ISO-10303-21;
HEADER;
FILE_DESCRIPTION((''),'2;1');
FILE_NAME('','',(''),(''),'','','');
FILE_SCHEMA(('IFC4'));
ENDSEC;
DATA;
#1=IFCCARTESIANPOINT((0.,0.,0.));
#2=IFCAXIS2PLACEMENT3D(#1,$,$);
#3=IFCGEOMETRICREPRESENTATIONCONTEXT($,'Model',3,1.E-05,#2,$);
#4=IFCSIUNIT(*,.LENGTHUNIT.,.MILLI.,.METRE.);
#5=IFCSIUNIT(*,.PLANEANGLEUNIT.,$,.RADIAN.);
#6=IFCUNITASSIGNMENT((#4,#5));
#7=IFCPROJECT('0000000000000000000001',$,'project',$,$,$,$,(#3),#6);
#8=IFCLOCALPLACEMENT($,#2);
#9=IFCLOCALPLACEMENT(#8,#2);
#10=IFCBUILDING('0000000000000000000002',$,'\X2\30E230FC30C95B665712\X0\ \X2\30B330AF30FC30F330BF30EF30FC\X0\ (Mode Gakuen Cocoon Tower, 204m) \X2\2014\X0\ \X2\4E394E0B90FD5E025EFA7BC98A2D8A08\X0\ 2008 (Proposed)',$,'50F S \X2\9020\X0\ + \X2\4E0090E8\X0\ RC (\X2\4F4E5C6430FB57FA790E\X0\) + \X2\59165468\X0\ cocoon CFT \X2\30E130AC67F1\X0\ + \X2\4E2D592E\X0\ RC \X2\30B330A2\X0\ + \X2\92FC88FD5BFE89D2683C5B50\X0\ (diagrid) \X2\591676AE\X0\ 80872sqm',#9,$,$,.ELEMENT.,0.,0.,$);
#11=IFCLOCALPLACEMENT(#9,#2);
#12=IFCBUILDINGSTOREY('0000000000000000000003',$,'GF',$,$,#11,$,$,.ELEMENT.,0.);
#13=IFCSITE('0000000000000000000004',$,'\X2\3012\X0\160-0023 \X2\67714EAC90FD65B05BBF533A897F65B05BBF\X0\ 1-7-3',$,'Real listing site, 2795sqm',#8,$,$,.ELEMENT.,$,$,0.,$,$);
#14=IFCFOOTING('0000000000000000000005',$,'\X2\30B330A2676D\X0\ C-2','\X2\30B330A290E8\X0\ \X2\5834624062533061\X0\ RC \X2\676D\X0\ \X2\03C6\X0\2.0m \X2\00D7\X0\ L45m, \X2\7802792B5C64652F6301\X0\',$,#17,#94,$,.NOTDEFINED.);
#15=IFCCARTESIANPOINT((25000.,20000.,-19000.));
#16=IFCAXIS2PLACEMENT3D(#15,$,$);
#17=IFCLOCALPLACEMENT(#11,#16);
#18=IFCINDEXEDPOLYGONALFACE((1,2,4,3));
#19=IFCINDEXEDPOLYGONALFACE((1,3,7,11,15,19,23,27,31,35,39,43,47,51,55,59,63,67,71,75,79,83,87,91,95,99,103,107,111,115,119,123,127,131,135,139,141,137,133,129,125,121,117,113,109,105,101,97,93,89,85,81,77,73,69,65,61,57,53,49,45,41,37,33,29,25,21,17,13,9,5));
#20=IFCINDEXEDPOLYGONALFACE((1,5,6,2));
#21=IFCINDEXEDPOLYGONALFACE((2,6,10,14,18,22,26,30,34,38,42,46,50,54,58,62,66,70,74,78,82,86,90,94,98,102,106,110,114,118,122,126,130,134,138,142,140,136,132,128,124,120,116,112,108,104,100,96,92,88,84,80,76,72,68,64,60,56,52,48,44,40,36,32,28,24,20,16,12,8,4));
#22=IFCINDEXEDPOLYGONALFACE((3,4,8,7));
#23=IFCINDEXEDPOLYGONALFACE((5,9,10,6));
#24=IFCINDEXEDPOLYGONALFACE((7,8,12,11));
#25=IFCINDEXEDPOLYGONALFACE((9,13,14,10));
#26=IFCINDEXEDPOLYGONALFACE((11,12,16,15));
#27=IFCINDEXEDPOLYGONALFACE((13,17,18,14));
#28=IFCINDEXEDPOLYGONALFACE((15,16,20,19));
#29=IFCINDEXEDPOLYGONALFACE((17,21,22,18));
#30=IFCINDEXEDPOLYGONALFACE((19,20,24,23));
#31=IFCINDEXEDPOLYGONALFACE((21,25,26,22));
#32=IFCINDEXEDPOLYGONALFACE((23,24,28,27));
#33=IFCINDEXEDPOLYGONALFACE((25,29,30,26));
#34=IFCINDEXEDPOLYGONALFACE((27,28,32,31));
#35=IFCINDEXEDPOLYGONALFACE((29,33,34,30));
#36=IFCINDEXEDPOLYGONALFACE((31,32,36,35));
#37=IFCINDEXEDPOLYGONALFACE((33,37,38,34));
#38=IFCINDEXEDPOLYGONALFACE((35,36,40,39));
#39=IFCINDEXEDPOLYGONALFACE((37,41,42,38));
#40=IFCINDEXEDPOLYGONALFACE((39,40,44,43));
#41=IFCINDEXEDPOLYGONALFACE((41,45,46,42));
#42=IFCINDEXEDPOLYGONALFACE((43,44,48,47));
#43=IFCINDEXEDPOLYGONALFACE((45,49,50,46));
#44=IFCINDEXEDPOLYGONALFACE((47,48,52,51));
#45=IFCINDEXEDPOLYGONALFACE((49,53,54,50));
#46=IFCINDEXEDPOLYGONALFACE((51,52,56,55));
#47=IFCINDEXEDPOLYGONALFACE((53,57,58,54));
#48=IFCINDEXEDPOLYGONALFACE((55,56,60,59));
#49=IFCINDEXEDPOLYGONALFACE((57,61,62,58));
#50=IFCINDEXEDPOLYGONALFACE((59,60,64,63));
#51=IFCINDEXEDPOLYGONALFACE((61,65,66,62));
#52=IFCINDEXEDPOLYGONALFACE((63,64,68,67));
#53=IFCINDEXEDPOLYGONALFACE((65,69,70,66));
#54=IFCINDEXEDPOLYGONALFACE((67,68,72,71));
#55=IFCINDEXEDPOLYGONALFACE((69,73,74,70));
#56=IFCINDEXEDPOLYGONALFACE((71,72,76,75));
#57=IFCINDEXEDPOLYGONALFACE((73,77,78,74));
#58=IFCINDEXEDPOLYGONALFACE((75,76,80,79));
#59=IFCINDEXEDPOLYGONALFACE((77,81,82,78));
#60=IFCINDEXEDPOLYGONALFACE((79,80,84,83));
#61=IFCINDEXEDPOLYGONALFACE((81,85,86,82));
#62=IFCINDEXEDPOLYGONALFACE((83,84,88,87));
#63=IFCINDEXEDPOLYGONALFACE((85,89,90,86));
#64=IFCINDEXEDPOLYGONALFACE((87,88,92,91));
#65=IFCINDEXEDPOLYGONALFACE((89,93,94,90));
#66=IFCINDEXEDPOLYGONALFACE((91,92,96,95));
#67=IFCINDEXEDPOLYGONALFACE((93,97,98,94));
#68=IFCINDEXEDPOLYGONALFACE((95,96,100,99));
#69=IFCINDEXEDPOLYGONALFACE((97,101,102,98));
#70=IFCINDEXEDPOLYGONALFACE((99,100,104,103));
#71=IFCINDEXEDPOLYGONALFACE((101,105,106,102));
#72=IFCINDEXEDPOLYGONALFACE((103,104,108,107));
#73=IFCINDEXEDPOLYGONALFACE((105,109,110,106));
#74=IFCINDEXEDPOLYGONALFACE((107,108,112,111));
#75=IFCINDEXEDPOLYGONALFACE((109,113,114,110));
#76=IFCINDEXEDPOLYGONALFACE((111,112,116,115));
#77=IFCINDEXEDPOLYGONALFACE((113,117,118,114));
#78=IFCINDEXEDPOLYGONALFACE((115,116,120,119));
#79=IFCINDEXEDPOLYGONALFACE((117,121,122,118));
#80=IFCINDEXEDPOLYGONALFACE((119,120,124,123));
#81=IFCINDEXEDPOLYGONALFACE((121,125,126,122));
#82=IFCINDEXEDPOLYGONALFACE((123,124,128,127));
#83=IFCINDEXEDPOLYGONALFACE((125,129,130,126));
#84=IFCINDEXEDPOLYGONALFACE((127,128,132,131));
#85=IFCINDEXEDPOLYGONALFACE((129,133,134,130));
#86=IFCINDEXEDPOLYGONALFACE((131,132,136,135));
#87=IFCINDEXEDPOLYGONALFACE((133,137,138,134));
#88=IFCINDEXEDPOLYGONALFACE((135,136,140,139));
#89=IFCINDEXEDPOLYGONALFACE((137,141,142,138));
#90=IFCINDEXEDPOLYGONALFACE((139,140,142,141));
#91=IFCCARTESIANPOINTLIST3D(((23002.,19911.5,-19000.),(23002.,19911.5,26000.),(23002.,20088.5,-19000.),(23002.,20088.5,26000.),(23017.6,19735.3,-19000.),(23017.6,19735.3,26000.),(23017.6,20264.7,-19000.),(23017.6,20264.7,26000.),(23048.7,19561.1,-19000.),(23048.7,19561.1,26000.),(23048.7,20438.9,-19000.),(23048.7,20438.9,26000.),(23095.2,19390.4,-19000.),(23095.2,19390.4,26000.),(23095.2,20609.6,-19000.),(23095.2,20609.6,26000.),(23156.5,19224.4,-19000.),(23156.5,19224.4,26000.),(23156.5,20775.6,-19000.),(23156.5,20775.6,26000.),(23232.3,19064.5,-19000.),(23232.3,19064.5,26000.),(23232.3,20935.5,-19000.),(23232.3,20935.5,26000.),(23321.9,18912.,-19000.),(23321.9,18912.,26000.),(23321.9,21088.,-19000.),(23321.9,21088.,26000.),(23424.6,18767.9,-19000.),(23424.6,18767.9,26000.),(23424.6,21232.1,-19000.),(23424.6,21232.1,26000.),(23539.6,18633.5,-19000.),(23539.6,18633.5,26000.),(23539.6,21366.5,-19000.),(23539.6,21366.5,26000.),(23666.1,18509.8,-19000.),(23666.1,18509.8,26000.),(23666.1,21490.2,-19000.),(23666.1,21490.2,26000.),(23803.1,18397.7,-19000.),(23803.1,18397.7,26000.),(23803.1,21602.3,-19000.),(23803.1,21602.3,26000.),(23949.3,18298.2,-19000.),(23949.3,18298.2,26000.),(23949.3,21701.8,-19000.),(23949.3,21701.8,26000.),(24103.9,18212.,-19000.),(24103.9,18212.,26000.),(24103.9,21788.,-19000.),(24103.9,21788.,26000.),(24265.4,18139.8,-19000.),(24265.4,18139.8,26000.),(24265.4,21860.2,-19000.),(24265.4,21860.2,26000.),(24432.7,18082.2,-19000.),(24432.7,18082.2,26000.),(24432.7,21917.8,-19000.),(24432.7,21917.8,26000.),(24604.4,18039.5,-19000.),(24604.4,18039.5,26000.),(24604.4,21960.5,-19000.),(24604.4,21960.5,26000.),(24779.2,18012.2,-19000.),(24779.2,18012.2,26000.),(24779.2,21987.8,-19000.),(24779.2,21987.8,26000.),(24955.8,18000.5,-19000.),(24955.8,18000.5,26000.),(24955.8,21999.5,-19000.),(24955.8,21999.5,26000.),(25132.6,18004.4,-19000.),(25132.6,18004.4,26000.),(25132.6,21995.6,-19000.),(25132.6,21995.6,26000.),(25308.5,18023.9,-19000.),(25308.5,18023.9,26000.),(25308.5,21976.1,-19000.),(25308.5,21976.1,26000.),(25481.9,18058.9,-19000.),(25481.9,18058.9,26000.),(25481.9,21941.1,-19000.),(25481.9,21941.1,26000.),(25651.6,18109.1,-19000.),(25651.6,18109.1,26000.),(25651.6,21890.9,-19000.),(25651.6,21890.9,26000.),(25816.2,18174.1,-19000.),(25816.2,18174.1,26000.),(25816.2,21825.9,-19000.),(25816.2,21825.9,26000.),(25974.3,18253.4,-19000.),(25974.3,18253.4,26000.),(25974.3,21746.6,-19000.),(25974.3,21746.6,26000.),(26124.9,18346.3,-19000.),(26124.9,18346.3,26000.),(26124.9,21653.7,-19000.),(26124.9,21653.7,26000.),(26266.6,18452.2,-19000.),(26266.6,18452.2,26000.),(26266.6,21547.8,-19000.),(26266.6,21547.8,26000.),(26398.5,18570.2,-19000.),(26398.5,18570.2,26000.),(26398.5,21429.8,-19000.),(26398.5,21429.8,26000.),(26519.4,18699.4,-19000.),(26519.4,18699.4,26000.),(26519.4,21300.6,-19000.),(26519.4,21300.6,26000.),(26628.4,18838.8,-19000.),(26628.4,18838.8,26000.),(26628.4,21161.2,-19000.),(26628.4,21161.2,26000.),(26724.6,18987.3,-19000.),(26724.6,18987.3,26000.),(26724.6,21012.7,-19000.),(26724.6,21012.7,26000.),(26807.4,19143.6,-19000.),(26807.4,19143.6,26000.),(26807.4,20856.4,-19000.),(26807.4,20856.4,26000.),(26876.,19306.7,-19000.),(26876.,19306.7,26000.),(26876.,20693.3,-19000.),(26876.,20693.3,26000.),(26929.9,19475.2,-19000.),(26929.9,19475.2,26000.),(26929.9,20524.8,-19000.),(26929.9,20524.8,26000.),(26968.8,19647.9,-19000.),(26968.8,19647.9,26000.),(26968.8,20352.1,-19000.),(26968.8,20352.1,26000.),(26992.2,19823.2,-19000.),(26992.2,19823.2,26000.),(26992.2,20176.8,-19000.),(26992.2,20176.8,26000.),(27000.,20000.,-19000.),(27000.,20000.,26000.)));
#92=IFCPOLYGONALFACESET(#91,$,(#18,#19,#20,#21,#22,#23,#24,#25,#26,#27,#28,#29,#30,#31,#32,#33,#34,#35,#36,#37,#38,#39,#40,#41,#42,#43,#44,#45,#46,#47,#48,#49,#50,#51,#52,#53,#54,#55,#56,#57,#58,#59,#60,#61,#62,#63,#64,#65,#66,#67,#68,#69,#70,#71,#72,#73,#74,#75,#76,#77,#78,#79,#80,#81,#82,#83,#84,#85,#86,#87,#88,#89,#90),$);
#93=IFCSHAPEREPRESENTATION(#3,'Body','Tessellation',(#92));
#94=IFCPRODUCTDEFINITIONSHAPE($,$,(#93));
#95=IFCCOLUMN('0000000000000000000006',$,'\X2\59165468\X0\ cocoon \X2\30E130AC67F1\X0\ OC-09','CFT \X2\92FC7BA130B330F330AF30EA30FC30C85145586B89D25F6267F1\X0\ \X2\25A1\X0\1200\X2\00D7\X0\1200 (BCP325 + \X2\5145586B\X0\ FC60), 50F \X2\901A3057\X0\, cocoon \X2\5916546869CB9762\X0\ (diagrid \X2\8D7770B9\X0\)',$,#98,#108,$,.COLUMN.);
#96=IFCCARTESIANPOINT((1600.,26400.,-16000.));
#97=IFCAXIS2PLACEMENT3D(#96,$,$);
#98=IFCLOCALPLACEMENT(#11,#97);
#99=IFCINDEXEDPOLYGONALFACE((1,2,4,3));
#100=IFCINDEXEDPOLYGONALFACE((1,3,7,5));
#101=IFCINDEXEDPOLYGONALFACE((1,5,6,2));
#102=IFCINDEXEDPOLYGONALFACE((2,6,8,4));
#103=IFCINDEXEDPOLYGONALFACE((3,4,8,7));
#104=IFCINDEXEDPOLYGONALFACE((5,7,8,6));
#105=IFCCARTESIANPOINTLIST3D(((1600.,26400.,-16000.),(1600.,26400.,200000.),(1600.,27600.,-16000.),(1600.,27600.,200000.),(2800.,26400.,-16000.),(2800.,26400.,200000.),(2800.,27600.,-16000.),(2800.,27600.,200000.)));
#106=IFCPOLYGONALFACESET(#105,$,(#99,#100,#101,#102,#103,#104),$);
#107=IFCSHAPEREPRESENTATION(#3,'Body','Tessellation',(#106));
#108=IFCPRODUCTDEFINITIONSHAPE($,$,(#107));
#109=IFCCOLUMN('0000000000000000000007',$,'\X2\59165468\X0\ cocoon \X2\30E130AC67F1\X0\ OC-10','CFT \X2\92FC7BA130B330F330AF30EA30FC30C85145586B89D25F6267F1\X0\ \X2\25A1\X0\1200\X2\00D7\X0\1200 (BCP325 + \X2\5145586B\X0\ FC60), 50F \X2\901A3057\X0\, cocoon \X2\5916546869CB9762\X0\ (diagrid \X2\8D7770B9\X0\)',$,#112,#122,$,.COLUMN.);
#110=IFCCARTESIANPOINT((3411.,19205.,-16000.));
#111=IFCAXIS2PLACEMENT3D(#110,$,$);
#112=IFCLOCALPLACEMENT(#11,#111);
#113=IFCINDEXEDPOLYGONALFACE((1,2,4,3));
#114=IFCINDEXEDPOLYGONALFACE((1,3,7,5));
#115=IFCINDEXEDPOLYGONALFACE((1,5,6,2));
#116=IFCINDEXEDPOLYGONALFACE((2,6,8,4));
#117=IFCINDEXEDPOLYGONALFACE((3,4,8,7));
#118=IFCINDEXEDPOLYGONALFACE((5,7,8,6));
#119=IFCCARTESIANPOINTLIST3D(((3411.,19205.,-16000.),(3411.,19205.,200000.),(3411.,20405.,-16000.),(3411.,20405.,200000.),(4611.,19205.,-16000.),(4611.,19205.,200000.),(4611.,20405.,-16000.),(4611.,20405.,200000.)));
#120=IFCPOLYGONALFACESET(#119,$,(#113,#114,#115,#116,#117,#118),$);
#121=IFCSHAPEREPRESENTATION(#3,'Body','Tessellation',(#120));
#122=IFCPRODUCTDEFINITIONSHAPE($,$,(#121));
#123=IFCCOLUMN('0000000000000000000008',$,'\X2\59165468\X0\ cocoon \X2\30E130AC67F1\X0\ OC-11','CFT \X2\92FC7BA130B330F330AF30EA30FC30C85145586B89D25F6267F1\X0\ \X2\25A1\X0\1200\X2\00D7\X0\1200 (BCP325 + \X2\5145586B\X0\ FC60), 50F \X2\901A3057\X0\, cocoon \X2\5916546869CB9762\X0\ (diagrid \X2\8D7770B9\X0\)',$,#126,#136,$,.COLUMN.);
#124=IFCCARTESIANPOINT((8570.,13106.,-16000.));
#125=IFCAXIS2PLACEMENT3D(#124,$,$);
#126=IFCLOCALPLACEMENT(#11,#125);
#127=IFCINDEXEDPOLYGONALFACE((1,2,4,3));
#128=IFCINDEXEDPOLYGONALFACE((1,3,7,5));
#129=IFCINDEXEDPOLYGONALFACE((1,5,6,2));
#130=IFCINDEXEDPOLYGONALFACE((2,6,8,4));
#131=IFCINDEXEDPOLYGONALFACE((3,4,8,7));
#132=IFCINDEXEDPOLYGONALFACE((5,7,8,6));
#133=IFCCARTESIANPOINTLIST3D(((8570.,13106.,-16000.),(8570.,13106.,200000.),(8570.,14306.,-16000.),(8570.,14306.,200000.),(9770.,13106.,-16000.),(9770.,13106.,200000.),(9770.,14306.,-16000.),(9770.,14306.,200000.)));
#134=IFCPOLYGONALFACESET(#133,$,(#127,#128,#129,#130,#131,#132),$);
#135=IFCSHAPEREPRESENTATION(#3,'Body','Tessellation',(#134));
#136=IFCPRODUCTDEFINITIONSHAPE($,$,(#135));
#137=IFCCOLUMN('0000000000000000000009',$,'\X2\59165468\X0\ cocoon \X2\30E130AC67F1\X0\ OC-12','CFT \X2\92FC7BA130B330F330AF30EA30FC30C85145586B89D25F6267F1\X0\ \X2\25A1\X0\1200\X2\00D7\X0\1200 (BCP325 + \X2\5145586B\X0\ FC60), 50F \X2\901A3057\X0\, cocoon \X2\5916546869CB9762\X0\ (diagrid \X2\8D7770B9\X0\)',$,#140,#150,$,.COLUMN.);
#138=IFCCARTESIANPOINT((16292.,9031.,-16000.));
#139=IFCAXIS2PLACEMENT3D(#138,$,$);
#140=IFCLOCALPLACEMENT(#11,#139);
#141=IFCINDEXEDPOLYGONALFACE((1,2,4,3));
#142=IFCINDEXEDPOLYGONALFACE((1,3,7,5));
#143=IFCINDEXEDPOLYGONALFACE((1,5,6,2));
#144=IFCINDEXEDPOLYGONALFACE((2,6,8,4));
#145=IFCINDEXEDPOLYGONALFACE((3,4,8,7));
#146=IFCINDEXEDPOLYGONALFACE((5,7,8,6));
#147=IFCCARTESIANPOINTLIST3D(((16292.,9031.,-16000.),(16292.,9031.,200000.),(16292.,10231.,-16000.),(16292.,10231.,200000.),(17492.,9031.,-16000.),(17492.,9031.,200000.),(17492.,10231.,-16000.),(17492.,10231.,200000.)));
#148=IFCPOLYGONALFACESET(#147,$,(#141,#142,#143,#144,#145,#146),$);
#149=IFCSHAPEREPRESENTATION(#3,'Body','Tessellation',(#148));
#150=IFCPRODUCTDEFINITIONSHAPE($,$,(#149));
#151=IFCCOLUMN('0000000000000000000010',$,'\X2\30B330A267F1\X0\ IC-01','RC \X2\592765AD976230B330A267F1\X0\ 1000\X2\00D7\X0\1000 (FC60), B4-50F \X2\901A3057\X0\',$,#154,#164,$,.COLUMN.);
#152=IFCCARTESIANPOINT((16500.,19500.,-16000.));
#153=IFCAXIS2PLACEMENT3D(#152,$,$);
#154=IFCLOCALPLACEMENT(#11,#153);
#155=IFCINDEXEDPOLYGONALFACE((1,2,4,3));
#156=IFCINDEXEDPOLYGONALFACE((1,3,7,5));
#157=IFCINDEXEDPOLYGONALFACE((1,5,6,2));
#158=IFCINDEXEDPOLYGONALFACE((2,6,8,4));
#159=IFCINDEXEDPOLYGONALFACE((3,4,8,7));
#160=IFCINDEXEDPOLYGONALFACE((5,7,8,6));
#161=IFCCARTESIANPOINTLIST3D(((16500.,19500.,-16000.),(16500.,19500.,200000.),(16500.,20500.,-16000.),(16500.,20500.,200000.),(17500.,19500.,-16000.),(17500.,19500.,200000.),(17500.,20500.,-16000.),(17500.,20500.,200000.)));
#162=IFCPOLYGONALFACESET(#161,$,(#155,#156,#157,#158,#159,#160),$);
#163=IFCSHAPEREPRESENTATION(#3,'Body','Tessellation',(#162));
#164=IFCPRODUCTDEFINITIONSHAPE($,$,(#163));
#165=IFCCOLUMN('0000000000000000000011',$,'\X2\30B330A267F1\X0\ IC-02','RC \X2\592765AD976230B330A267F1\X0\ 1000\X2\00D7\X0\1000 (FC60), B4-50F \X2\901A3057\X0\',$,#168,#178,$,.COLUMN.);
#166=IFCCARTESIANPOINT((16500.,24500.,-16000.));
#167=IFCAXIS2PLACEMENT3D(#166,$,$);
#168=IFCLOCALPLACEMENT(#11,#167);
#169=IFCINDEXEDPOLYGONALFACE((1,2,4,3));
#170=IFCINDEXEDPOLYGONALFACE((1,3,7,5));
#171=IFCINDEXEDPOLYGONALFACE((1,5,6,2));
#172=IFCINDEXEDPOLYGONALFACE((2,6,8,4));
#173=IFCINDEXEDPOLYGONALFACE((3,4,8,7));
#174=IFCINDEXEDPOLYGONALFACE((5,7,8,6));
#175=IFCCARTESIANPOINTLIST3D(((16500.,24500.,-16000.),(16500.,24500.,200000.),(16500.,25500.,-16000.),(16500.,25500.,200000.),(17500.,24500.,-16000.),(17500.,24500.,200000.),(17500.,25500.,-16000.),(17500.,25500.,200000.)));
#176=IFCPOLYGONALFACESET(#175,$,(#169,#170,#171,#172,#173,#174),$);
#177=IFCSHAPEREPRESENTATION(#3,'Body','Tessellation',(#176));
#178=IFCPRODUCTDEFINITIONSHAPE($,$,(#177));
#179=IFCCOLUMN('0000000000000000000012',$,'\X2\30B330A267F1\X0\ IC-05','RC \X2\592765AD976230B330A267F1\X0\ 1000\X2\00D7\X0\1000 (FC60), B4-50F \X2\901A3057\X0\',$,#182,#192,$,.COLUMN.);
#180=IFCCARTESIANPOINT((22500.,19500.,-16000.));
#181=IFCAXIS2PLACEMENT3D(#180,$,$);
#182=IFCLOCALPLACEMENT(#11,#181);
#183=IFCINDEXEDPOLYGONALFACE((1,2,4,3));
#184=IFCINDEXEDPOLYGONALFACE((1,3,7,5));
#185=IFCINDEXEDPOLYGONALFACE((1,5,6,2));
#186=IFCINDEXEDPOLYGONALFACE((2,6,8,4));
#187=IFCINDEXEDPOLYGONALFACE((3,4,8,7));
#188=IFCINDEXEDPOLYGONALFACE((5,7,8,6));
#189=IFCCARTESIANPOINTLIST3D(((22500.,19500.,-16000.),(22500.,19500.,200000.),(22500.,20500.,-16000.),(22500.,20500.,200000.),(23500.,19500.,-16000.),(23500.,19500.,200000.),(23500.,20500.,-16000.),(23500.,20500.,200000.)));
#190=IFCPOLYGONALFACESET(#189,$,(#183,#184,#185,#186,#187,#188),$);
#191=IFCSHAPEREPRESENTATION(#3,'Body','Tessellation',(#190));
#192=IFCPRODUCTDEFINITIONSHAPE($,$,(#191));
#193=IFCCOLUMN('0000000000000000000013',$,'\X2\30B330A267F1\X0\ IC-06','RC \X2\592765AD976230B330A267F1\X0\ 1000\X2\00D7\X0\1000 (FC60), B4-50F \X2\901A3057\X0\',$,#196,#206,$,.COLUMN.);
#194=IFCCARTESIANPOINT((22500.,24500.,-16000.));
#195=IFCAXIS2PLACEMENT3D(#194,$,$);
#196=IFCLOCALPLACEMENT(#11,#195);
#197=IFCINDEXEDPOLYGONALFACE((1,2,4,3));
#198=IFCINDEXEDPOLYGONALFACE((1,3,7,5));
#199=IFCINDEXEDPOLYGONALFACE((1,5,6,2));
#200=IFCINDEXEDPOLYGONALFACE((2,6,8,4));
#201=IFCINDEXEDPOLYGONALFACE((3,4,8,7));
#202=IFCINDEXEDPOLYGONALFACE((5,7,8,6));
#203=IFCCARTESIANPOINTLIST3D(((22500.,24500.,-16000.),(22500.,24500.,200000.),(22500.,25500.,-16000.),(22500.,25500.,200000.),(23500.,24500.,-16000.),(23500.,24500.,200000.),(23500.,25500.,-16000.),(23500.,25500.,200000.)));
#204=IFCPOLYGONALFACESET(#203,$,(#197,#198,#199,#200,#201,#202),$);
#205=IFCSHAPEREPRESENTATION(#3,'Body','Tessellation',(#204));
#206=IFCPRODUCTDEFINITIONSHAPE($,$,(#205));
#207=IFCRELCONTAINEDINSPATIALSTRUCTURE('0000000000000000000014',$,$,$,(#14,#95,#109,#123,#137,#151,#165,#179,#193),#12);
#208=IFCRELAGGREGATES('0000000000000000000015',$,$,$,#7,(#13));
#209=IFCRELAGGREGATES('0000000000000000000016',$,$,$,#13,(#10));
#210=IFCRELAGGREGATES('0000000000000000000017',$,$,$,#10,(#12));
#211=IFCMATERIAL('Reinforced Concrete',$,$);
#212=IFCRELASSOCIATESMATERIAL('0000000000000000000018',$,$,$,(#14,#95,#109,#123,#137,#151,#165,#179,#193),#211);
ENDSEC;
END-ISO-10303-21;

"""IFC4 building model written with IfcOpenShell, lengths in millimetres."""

from ifc_helpers import new_model, si_unit, frame, frame_2d, origin, origin_2d, place, context, project, spatial, rectangle, circle, extrude, material, element, save


model = new_model("IFC4")

# Units and contexts
model_context = context("Model", 3, precision=1e-05, world=origin())
ifc_project = project(units=[si_unit("LENGTHUNIT", "METRE", prefix="MILLI"), si_unit("PLANEANGLEUNIT", "RADIAN")], contexts=[model_context])

# Site, building, storey
site_placement = place(None, origin())
site = spatial("IfcSite", under=ifc_project, at=site_placement, Name="〒160-0023 東京都新宿区西新宿 1-7-3", ObjectType="Real listing site, 2795sqm", CompositionType="ELEMENT", RefElevation=0.0)
building_placement = place(site_placement, origin())
building = spatial("IfcBuilding", under=site, at=building_placement, Name="モード学園 コクーンタワー (Mode Gakuen Cocoon Tower, 204m) — 丹下都市建築設計 2008 (Proposed)", ObjectType="50F S 造 + 一部 RC (低層・基礎) + 外周 cocoon CFT メガ柱 + 中央 RC コア + 鋼製対角格子 (diagrid) 外皮 80872sqm", CompositionType="ELEMENT", ElevationOfRefHeight=0.0, ElevationOfTerrain=0.0)
storey_placement = place(building_placement, origin())
storey = spatial("IfcBuildingStorey", under=building, at=storey_placement, Name="GF", CompositionType="ELEMENT", Elevation=0.0)

# Footing
ifc_material_1 = material(Name="Reinforced Concrete")
footing_1_placement = place(storey_placement, frame((25000.0, 20000.0, -19000.0)))
element("IfcFooting", 1, at=footing_1_placement, inside=storey, material=ifc_material_1, Name="コア杭 C-2", Description="コア部 場所打ち RC 杭 φ2.0m × L45m, 砂礫層支持", PredefinedType="NOTDEFINED", context=model_context, shape_type="SweptSolid", body=[
    extrude(circle(Radius=2000.0, at=origin_2d()), frame((25000.0, 20000.0, -19000.0)), (0.0, 0.0, 1.0), 45000.0),
])

# Columns
column_1_placement = place(storey_placement, frame((1600.0, 26400.0, -16000.0)))
element("IfcColumn", 2, at=column_1_placement, inside=storey, material=ifc_material_1, Name="外周 cocoon メガ柱 OC-09", Description="CFT 鋼管コンクリート充填角形柱 □1200×1200 (BCP325 + 充填 FC60), 50F 通し, cocoon 外周構面 (diagrid 起点)", PredefinedType="COLUMN", context=model_context, shape_type="SweptSolid", body=[
    extrude(rectangle(XDim=1200.0, YDim=1200.0, at=frame_2d((600.0, 600.0))), frame((1600.0, 26400.0, -16000.0)), (0.0, 0.0, 1.0), 216000.0),
])
column_2_placement = place(storey_placement, frame((3411.0, 19205.0, -16000.0)))
element("IfcColumn", 3, at=column_2_placement, inside=storey, material=ifc_material_1, Name="外周 cocoon メガ柱 OC-10", Description="CFT 鋼管コンクリート充填角形柱 □1200×1200 (BCP325 + 充填 FC60), 50F 通し, cocoon 外周構面 (diagrid 起点)", PredefinedType="COLUMN", context=model_context, shape_type="SweptSolid", body=[
    extrude(rectangle(XDim=1200.0, YDim=1200.0, at=frame_2d((600.0, 600.0))), frame((3411.0, 19205.0, -16000.0)), (0.0, 0.0, 1.0), 216000.0),
])
column_3_placement = place(storey_placement, frame((8570.0, 13106.0, -16000.0)))
element("IfcColumn", 4, at=column_3_placement, inside=storey, material=ifc_material_1, Name="外周 cocoon メガ柱 OC-11", Description="CFT 鋼管コンクリート充填角形柱 □1200×1200 (BCP325 + 充填 FC60), 50F 通し, cocoon 外周構面 (diagrid 起点)", PredefinedType="COLUMN", context=model_context, shape_type="SweptSolid", body=[
    extrude(rectangle(XDim=1200.0, YDim=1200.0, at=frame_2d((600.0, 600.0))), frame((8570.0, 13106.0, -16000.0)), (0.0, 0.0, 1.0), 216000.0),
])
column_4_placement = place(storey_placement, frame((16292.0, 9031.0, -16000.0)))
element("IfcColumn", 5, at=column_4_placement, inside=storey, material=ifc_material_1, Name="外周 cocoon メガ柱 OC-12", Description="CFT 鋼管コンクリート充填角形柱 □1200×1200 (BCP325 + 充填 FC60), 50F 通し, cocoon 外周構面 (diagrid 起点)", PredefinedType="COLUMN", context=model_context, shape_type="SweptSolid", body=[
    extrude(rectangle(XDim=1200.0, YDim=1200.0, at=frame_2d((600.0, 600.0))), frame((16292.0, 9031.0, -16000.0)), (0.0, 0.0, 1.0), 216000.0),
])
column_5_placement = place(storey_placement, frame((16500.0, 19500.0, -16000.0)))
element("IfcColumn", 6, at=column_5_placement, inside=storey, material=ifc_material_1, Name="コア柱 IC-01", Description="RC 大断面コア柱 1000×1000 (FC60), B4-50F 通し", PredefinedType="COLUMN", context=model_context, shape_type="SweptSolid", body=[
    extrude(rectangle(XDim=1000.0, YDim=1000.0, at=frame_2d((500.0, 500.0))), frame((16500.0, 19500.0, -16000.0)), (0.0, 0.0, 1.0), 216000.0),
])
column_6_placement = place(storey_placement, frame((16500.0, 24500.0, -16000.0)))
element("IfcColumn", 7, at=column_6_placement, inside=storey, material=ifc_material_1, Name="コア柱 IC-02", Description="RC 大断面コア柱 1000×1000 (FC60), B4-50F 通し", PredefinedType="COLUMN", context=model_context, shape_type="SweptSolid", body=[
    extrude(rectangle(XDim=1000.0, YDim=1000.0, at=frame_2d((500.0, 500.0))), frame((16500.0, 24500.0, -16000.0)), (0.0, 0.0, 1.0), 216000.0),
])
column_7_placement = place(storey_placement, frame((22500.0, 19500.0, -16000.0)))
element("IfcColumn", 8, at=column_7_placement, inside=storey, material=ifc_material_1, Name="コア柱 IC-05", Description="RC 大断面コア柱 1000×1000 (FC60), B4-50F 通し", PredefinedType="COLUMN", context=model_context, shape_type="SweptSolid", body=[
    extrude(rectangle(XDim=1000.0, YDim=1000.0, at=frame_2d((500.0, 500.0))), frame((22500.0, 19500.0, -16000.0)), (0.0, 0.0, 1.0), 216000.0),
])
column_8_placement = place(storey_placement, frame((22500.0, 24500.0, -16000.0)))
element("IfcColumn", 9, at=column_8_placement, inside=storey, material=ifc_material_1, Name="コア柱 IC-06", Description="RC 大断面コア柱 1000×1000 (FC60), B4-50F 通し", PredefinedType="COLUMN", context=model_context, shape_type="SweptSolid", body=[
    extrude(rectangle(XDim=1000.0, YDim=1000.0, at=frame_2d((500.0, 500.0))), frame((22500.0, 24500.0, -16000.0)), (0.0, 0.0, 1.0), 216000.0),
])

save(model, "model.ifc")
